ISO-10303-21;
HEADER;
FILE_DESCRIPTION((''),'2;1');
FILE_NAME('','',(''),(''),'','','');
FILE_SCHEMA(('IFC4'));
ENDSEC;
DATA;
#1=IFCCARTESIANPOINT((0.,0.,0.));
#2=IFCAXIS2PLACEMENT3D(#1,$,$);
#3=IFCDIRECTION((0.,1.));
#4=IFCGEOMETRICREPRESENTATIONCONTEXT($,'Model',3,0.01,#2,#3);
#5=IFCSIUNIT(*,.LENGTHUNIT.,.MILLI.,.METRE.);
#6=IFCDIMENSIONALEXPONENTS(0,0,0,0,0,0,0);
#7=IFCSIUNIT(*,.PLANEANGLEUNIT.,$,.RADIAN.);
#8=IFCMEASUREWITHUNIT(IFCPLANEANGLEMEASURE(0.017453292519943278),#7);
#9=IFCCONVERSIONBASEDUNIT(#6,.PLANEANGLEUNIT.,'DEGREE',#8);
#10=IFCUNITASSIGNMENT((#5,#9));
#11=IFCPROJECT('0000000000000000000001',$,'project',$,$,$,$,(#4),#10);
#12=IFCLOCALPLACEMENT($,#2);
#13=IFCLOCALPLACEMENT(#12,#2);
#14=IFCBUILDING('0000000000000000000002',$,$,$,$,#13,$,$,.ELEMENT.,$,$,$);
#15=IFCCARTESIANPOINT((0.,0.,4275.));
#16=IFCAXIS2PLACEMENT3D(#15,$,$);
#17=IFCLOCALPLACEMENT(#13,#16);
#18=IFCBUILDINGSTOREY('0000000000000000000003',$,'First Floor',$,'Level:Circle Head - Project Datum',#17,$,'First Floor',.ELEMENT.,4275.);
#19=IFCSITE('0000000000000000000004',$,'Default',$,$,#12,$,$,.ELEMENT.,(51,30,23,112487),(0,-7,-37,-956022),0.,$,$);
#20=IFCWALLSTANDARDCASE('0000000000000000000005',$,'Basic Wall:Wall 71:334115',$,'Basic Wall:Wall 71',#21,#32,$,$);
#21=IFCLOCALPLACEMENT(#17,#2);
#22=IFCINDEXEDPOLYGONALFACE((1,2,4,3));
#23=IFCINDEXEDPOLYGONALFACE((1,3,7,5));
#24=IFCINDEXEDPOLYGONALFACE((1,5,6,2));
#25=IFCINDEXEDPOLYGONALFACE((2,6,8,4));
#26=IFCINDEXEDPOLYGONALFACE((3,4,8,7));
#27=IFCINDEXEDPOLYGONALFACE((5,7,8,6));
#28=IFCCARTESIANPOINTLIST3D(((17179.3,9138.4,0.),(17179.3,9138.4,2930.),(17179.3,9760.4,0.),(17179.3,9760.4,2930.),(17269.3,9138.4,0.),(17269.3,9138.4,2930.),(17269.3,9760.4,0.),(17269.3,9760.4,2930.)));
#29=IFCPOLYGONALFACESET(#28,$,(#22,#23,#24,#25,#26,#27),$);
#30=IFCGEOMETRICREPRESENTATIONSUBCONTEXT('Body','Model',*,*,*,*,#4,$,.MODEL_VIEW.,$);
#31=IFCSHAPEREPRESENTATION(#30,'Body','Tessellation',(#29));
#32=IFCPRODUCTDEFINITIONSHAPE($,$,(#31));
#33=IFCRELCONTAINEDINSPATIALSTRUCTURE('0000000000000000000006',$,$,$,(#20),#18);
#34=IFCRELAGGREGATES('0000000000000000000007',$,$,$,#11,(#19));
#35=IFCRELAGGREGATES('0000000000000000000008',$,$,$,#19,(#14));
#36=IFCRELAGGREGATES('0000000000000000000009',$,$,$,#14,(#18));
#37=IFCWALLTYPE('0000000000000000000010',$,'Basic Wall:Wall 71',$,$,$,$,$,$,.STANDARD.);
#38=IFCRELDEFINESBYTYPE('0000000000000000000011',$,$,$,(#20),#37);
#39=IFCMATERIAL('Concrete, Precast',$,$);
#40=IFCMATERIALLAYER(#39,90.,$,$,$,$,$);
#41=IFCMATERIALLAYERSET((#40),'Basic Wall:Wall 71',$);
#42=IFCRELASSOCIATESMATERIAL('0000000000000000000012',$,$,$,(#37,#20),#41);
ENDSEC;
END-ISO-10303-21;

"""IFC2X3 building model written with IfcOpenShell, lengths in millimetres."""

from ifc_helpers import new_model, entity, si_unit, converted_unit, direction, frame, frame_2d, origin, place, context, subcontext, project, spatial, polyline, rectangle, extrude, clip, bounded_halfspace, material, layer, layer_set, layer_usage, type_object, element, save


model = new_model("IFC2X3")

# Units and contexts
model_context = context("Model", 3, precision=0.01, world=origin(), true_north=direction((0.0, 1.0)))
body_context = subcontext(model_context, "Body", "Model", "MODEL_VIEW")
ifc_project = project(units=[si_unit("LENGTHUNIT", "METRE", prefix="MILLI"), converted_unit("PLANEANGLEUNIT", "DEGREE", entity("IfcPlaneAngleMeasure", 0.017453292519943278), si_unit("PLANEANGLEUNIT", "RADIAN"), dimensions=[0, 0, 0, 0, 0, 0, 0])], contexts=[model_context])

# Site, building, storey
site_placement = place(None, origin())
site = spatial("IfcSite", under=ifc_project, at=site_placement, Name="Default", CompositionType="ELEMENT", RefLatitude=(51, 30, 23, 112487), RefLongitude=(0, -7, -37, -956022), RefElevation=0.0)
building_placement = place(site_placement, origin())
building = spatial("IfcBuilding", under=site, at=building_placement, CompositionType="ELEMENT")
storey_placement = place(building_placement, frame((0.0, 0.0, 4275.0)))
storey = spatial("IfcBuildingStorey", under=building, at=storey_placement, Name="First Floor", ObjectType="Level:Circle Head - Project Datum", LongName="First Floor", CompositionType="ELEMENT", Elevation=4275.0)

# Shared definitions
ifc_material_1 = material(Name="Concrete, Precast")

# Shared definitions
ifc_layer_1 = layer(ifc_material_1, 90.0)
ifc_layer_set_1 = layer_set([ifc_layer_1], Name="Basic Wall:Wall 71")
wall_type_1 = type_object("IfcWallType", Name="Basic Wall:Wall 71", PredefinedType="STANDARD", material=ifc_layer_set_1)

# Wall
ifc_layer_usage_1 = layer_usage(ifc_layer_set_1, "AXIS2", "NEGATIVE", 45.0)
wall_1_placement = place(storey_placement, frame((17224.3, 9760.4, 0.0), z_axis=(0.0, 0.0, 1.0), x_axis=(0.0, -1.0, 0.0)))
element("IfcWallStandardCase", 1, at=wall_1_placement, inside=storey, type_object=wall_type_1, material=ifc_layer_usage_1, Name="Basic Wall:Wall 71:334115", ObjectType="Basic Wall:Wall 71", context=body_context, shape_type="Clipping", body=[
    clip(extrude(rectangle(XDim=622.0, YDim=90.0, at=frame_2d((311.0, 0.0), x_axis=(-1.0, 0.0))), origin(), (0.0, 0.0, 1.0), 2930.0), bounded_halfspace(frame((0.0, -45.0, 2930.0), z_axis=(0.0, 0.0, -1.0), x_axis=(1.0, 0.0, 0.0)), True, frame((0.0, -45.0, 2930.0)), polyline([(0.0, 0.0), (622.0, 0.0), (622.0, 90.0), (0.0, 90.0), (0.0, 0.0)]))),
])

save(model, "model.ifc")
